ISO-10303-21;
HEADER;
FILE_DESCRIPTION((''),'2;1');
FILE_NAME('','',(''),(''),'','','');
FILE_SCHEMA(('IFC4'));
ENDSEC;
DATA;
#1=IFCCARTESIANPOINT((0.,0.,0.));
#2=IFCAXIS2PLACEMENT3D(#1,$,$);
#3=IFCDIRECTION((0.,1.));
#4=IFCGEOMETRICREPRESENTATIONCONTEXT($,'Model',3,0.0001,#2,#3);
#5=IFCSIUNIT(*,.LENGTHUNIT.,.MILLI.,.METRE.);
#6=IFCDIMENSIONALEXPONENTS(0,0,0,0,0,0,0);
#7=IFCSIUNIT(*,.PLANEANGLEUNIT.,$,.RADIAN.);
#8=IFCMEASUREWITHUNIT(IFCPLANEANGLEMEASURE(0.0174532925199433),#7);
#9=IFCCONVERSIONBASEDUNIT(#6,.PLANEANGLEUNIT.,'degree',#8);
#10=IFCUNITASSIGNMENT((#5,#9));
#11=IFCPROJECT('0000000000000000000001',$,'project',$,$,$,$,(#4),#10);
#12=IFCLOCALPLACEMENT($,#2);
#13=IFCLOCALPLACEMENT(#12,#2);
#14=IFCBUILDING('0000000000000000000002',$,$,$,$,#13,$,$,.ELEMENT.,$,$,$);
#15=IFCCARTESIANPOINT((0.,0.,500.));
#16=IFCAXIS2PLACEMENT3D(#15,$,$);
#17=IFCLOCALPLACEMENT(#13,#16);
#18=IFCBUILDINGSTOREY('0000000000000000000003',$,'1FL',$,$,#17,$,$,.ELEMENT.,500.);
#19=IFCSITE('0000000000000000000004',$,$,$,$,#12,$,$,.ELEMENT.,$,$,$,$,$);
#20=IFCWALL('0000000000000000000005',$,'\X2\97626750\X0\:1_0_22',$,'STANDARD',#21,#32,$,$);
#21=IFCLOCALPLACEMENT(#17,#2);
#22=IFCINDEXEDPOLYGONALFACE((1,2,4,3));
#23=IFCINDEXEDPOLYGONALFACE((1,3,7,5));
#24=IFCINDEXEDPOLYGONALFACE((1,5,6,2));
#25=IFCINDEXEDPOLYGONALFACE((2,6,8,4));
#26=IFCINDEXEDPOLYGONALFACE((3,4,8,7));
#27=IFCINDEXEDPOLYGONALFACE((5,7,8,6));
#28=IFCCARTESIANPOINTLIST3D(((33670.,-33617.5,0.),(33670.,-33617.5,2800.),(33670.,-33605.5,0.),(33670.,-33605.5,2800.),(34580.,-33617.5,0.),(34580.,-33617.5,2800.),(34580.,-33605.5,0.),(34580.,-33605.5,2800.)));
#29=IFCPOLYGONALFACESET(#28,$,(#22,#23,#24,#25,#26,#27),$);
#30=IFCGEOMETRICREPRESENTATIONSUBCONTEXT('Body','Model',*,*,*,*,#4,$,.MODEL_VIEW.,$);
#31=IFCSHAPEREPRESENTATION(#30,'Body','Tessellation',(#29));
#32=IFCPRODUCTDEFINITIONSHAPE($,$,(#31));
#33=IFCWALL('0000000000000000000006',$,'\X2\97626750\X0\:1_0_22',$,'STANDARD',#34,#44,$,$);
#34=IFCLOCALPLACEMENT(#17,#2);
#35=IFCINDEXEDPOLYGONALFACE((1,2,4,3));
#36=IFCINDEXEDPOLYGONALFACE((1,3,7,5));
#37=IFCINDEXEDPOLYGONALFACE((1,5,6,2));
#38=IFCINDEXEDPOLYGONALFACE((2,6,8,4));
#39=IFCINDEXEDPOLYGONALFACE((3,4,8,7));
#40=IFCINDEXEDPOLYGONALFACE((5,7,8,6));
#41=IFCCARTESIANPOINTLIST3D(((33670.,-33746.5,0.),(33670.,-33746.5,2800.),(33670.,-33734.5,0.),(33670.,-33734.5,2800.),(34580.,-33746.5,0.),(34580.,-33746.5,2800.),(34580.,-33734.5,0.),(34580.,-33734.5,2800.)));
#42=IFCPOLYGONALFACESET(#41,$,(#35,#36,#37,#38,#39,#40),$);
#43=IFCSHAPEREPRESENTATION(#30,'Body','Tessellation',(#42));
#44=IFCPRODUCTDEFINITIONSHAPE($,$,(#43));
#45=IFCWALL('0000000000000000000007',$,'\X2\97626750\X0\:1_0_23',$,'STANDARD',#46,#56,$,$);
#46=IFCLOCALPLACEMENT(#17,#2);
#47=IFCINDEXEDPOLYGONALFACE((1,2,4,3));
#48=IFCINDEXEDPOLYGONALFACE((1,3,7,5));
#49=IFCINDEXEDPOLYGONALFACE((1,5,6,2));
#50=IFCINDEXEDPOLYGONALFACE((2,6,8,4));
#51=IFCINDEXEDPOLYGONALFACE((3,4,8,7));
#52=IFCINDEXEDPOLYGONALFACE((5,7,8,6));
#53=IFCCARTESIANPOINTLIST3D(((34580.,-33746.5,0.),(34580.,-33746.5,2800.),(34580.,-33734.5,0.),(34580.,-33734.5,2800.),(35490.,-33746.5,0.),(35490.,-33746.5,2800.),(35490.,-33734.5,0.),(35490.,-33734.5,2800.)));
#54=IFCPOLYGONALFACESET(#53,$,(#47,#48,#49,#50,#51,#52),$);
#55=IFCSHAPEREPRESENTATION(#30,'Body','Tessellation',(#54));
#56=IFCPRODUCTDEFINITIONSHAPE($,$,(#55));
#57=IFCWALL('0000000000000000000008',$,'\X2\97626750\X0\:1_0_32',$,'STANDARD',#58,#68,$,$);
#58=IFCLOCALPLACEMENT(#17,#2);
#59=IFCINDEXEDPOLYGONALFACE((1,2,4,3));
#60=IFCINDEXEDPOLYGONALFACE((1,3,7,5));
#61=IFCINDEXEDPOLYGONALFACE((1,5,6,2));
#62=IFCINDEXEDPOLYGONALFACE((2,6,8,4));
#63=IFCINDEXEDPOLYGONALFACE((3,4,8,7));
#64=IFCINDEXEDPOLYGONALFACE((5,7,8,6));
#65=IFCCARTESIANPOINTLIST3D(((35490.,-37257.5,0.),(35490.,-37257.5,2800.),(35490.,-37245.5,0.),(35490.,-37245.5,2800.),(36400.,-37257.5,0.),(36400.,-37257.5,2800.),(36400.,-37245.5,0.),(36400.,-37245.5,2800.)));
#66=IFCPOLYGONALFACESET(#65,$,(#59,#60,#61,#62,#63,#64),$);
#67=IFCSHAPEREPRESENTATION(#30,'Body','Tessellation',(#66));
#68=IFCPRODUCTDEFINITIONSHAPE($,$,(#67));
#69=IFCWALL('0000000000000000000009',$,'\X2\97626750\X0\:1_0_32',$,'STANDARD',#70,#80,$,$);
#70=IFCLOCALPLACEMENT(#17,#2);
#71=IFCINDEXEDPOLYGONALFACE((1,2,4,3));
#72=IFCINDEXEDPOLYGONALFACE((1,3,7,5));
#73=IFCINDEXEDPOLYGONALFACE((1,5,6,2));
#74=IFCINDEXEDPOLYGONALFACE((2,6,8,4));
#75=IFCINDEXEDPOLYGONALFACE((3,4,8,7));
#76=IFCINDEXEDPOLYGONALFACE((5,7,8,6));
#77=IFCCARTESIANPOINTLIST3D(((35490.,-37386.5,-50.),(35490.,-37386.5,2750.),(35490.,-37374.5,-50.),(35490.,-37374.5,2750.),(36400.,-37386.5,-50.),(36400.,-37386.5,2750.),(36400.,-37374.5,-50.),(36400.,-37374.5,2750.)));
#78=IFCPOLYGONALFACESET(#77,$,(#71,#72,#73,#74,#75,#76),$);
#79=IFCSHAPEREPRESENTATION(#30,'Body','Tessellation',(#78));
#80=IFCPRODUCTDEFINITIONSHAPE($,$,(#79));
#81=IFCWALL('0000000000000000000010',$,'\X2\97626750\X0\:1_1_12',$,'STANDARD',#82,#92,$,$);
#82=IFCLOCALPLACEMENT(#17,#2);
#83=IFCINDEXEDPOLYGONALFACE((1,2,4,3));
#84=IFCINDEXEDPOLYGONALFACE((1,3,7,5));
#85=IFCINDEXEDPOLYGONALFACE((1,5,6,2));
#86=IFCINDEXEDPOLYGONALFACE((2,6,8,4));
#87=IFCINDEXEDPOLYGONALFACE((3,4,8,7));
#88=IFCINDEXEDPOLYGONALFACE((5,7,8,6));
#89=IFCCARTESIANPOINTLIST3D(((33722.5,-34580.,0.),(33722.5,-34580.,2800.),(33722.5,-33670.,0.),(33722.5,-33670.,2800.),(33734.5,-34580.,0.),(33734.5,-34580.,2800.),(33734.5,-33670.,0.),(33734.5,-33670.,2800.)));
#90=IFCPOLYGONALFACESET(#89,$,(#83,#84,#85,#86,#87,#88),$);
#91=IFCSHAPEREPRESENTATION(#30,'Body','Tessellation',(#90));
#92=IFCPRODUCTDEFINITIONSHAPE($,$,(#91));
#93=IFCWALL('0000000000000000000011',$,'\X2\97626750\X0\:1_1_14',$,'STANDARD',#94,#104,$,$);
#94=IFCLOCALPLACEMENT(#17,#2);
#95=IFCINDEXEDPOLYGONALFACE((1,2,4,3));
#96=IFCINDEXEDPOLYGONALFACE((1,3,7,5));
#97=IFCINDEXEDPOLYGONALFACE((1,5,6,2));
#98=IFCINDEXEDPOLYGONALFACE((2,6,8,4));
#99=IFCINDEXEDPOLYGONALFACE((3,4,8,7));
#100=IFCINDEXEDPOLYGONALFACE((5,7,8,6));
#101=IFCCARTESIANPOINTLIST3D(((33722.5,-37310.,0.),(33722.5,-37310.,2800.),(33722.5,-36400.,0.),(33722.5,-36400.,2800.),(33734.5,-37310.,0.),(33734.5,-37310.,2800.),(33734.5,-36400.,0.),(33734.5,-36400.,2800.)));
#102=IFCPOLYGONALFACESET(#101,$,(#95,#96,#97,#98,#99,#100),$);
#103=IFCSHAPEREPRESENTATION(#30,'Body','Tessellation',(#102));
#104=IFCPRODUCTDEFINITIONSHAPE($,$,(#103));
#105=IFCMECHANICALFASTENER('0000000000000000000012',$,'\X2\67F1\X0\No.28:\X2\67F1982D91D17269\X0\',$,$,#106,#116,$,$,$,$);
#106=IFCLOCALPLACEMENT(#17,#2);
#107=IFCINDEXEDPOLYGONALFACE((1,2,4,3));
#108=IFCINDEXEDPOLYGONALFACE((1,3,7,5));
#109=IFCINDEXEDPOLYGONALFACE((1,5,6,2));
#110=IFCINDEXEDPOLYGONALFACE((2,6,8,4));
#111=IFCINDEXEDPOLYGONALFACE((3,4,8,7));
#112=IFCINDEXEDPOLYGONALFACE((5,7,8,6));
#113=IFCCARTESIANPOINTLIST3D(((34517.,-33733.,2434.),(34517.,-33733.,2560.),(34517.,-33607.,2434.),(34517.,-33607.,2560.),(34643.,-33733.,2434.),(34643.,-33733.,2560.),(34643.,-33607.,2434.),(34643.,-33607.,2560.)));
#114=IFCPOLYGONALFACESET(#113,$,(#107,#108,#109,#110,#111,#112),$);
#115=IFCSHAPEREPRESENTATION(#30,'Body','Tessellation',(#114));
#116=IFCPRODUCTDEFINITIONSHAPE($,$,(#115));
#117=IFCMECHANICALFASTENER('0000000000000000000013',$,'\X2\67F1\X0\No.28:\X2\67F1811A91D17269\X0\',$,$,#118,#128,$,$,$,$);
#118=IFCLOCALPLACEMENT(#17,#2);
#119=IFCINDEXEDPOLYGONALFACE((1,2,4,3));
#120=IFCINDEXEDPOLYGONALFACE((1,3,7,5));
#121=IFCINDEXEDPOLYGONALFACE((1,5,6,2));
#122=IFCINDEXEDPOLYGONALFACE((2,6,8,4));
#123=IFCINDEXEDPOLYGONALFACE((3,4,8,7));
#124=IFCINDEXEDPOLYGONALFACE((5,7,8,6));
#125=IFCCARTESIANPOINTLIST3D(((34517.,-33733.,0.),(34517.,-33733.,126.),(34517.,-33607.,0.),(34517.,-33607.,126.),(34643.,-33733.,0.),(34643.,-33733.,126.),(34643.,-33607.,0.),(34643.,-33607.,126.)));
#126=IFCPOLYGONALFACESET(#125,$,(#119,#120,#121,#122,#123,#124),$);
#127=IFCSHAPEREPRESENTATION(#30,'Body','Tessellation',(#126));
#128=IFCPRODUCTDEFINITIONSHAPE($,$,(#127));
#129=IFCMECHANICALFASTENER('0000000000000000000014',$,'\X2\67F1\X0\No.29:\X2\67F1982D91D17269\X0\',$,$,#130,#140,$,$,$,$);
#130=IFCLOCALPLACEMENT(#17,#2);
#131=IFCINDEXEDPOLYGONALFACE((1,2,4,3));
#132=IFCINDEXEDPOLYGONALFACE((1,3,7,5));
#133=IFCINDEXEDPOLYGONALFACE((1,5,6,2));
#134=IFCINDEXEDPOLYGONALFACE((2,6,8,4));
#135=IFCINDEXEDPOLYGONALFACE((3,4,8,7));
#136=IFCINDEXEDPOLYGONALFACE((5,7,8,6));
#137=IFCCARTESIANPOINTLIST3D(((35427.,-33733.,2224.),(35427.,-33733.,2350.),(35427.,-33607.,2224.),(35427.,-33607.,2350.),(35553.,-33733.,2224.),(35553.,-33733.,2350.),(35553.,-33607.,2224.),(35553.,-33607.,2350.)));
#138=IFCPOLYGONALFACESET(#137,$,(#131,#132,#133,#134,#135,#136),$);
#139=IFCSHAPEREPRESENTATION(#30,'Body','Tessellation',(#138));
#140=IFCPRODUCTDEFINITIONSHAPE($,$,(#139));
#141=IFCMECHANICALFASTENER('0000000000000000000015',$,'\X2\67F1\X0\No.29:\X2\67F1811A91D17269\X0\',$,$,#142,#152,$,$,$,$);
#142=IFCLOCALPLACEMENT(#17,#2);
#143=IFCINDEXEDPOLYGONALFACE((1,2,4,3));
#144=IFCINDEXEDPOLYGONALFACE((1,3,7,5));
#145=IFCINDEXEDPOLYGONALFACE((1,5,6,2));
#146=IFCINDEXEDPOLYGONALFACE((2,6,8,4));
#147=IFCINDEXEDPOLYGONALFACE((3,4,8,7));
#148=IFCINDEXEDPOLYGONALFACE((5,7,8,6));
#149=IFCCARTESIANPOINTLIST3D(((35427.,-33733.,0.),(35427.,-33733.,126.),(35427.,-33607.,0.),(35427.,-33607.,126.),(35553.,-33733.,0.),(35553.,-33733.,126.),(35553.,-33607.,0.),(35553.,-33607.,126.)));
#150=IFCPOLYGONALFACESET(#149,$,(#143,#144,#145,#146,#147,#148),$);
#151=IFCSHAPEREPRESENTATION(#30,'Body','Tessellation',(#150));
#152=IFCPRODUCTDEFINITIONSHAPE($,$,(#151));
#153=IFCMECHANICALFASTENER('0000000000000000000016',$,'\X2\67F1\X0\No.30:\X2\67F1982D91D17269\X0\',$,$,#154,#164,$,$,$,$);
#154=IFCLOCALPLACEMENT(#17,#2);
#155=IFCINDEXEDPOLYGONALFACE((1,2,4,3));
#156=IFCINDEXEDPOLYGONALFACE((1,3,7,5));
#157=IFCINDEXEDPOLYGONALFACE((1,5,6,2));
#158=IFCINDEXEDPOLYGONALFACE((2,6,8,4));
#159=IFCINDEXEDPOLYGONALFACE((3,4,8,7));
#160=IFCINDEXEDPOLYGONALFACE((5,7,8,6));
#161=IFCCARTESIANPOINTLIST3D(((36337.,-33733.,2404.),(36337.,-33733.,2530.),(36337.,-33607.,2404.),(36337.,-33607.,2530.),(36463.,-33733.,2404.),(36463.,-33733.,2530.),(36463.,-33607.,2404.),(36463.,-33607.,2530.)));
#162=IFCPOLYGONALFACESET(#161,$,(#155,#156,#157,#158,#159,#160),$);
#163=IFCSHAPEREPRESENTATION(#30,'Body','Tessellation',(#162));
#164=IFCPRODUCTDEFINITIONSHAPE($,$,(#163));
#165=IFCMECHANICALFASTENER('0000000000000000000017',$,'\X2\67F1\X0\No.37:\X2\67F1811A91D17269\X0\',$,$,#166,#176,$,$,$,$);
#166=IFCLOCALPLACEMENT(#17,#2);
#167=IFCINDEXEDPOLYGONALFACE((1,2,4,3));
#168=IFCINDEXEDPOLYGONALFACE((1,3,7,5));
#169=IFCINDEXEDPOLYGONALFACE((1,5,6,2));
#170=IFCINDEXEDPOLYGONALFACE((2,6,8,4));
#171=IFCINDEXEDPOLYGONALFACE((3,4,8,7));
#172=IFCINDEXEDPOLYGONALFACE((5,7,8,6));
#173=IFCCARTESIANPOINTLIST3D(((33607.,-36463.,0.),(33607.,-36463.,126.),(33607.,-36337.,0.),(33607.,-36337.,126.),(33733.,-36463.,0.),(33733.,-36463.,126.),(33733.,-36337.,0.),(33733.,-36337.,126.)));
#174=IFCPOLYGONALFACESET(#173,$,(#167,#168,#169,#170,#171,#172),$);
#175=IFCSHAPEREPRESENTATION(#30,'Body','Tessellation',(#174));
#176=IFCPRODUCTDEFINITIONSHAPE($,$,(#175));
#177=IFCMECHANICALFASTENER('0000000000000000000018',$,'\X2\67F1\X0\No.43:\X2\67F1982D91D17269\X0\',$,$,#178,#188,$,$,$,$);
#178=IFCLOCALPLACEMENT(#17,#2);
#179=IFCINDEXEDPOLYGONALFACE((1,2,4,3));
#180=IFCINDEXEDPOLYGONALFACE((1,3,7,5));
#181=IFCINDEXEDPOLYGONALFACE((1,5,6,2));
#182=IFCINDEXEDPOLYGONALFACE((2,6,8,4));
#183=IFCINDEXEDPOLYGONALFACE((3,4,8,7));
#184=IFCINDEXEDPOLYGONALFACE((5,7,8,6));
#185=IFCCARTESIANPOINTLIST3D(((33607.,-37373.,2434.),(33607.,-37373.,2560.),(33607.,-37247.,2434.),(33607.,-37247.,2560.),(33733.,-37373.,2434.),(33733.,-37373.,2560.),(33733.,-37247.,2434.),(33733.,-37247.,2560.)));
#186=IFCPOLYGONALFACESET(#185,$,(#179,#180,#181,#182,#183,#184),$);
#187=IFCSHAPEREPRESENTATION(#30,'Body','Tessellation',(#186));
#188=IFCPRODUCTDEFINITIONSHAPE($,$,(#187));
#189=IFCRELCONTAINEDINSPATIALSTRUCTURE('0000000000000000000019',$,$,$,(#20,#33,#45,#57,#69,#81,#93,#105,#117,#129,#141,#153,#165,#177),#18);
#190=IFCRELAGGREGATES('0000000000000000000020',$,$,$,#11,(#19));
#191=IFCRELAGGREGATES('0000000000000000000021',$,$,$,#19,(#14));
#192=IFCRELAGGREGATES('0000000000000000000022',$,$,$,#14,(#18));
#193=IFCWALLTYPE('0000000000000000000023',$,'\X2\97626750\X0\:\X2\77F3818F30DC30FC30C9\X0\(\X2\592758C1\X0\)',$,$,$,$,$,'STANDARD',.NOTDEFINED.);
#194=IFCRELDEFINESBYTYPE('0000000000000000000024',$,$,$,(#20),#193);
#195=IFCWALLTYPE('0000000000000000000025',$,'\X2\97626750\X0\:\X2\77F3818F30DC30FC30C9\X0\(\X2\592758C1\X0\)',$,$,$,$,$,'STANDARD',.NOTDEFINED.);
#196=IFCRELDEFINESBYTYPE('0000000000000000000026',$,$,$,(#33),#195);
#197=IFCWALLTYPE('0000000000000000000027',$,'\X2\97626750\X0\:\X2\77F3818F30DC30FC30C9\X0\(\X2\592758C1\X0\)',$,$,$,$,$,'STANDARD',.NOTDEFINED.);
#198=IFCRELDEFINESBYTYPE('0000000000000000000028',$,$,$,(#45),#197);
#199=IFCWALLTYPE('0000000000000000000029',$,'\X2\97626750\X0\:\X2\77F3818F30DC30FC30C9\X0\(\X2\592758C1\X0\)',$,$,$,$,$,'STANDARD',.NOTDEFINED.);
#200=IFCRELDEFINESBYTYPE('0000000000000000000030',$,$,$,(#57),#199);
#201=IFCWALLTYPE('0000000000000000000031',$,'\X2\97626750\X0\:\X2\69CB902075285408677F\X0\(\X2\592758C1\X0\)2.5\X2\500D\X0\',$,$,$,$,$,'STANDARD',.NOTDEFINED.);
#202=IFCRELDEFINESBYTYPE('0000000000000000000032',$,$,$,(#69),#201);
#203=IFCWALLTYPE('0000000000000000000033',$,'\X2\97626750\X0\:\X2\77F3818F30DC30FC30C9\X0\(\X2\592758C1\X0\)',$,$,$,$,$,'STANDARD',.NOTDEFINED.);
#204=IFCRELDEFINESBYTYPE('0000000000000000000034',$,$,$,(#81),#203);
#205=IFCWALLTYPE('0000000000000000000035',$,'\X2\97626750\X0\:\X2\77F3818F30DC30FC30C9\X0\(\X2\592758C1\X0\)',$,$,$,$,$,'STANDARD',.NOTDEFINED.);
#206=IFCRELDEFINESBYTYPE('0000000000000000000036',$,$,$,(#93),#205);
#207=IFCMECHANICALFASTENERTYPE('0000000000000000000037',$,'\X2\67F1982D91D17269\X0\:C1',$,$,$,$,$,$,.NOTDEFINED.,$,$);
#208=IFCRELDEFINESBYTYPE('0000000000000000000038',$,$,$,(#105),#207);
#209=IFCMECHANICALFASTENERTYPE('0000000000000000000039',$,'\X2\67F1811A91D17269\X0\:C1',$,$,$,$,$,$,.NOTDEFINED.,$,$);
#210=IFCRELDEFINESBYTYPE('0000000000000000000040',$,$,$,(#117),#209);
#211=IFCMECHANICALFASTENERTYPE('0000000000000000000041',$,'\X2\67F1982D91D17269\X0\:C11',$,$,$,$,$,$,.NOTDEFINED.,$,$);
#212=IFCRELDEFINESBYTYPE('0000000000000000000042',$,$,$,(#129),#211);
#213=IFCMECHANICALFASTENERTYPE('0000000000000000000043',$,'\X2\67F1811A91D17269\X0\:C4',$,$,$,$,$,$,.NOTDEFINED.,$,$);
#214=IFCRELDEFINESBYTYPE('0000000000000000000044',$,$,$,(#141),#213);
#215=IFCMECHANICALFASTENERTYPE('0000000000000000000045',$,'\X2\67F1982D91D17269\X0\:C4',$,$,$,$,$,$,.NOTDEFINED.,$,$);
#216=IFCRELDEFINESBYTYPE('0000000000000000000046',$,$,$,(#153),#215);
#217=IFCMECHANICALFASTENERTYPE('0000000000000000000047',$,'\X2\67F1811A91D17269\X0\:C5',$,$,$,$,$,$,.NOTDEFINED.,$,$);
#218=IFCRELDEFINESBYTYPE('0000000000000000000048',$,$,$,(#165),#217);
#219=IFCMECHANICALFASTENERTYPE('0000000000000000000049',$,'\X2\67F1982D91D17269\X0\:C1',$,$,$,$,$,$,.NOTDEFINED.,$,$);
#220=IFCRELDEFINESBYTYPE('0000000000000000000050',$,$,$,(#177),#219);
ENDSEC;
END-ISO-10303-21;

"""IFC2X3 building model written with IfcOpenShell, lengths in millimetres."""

from ifc_helpers import new_model, entity, si_unit, converted_unit, direction, frame, origin, origin_with_axes, origin_2d, place, context, subcontext, project, spatial, polyline, rectangle, outline, extrude, type_object, element, save


model = new_model("IFC2X3")

# Units and contexts
model_context = context("Model", 3, precision=0.0001, world=origin(), true_north=direction((0.0, 1.0)))
body_context = subcontext(model_context, "Body", "Model", "MODEL_VIEW")
ifc_project = project(units=[si_unit("LENGTHUNIT", "METRE", prefix="MILLI"), converted_unit("PLANEANGLEUNIT", "degree", entity("IfcPlaneAngleMeasure", 0.0174532925199433), si_unit("PLANEANGLEUNIT", "RADIAN"), dimensions=[0, 0, 0, 0, 0, 0, 0])], contexts=[model_context])

# Site, building, storey
site_placement = place(None, origin())
site = spatial("IfcSite", under=ifc_project, at=site_placement, CompositionType="ELEMENT")
building_placement = place(site_placement, origin())
building = spatial("IfcBuilding", under=site, at=building_placement, CompositionType="ELEMENT")
storey_placement = place(building_placement, frame((0.0, 0.0, 500.0)))
storey = spatial("IfcBuildingStorey", under=building, at=storey_placement, Name="1FL", CompositionType="ELEMENT", Elevation=500.0)

# Walls
wall_type_1 = type_object("IfcWallType", Name="面材:石膏ボード(大壁)", ElementType="STANDARD", PredefinedType="NOTDEFINED")
wall_1_placement = place(storey_placement, frame((34125.0, -33605.5, 0.0), z_axis=(0.0, -1.0, 0.0), x_axis=(1.0, 0.0, 0.0)))
element("IfcWall", 1, at=wall_1_placement, inside=storey, type_object=wall_type_1, Name="面材:1_0_22", ObjectType="STANDARD", context=body_context, shape_type="SweptSolid", body=[
    extrude(outline(polyline([(455.0, 0.0, 0.0), (-455.0, 0.0, 0.0), (-455.0, 2800.0, 0.0), (455.0, 2800.0, 0.0), (455.0, 0.0, 0.0)])), origin_with_axes(), (0.0, 0.0, 1.0), 12.0),
])
wall_type_2 = type_object("IfcWallType", Name="面材:石膏ボード(大壁)", ElementType="STANDARD", PredefinedType="NOTDEFINED")
wall_2_placement = place(storey_placement, frame((34125.0, -33734.5, 0.0), z_axis=(0.0, -1.0, 0.0), x_axis=(1.0, 0.0, 0.0)))
element("IfcWall", 2, at=wall_2_placement, inside=storey, type_object=wall_type_2, Name="面材:1_0_22", ObjectType="STANDARD", context=body_context, shape_type="SweptSolid", body=[
    extrude(outline(polyline([(455.0, 0.0, 0.0), (-455.0, 0.0, 0.0), (-455.0, 2800.0, 0.0), (455.0, 2800.0, 0.0), (455.0, 0.0, 0.0)])), origin_with_axes(), (0.0, 0.0, 1.0), 12.0),
])
wall_type_3 = type_object("IfcWallType", Name="面材:石膏ボード(大壁)", ElementType="STANDARD", PredefinedType="NOTDEFINED")
wall_3_placement = place(storey_placement, frame((35035.0, -33734.5, 0.0), z_axis=(0.0, -1.0, 0.0), x_axis=(1.0, 0.0, 0.0)))
element("IfcWall", 3, at=wall_3_placement, inside=storey, type_object=wall_type_3, Name="面材:1_0_23", ObjectType="STANDARD", context=body_context, shape_type="SweptSolid", body=[
    extrude(outline(polyline([(455.0, 0.0, 0.0), (-455.0, 0.0, 0.0), (-455.0, 2800.0, 0.0), (455.0, 2800.0, 0.0), (455.0, 0.0, 0.0)])), origin_with_axes(), (0.0, 0.0, 1.0), 12.0),
])
wall_type_4 = type_object("IfcWallType", Name="面材:石膏ボード(大壁)", ElementType="STANDARD", PredefinedType="NOTDEFINED")
wall_4_placement = place(storey_placement, frame((35945.0, -37245.5, 0.0), z_axis=(0.0, -1.0, 0.0), x_axis=(1.0, 0.0, 0.0)))
element("IfcWall", 4, at=wall_4_placement, inside=storey, type_object=wall_type_4, Name="面材:1_0_32", ObjectType="STANDARD", context=body_context, shape_type="SweptSolid", body=[
    extrude(outline(polyline([(455.0, 0.0, 0.0), (-455.0, 0.0, 0.0), (-455.0, 2800.0, 0.0), (455.0, 2800.0, 0.0), (455.0, 0.0, 0.0)])), origin_with_axes(), (0.0, 0.0, 1.0), 12.0),
])
wall_type_5 = type_object("IfcWallType", Name="面材:構造用合板(大壁)2.5倍", ElementType="STANDARD", PredefinedType="NOTDEFINED")
wall_5_placement = place(storey_placement, frame((35945.0, -37374.5, -50.0), z_axis=(0.0, -1.0, 0.0), x_axis=(1.0, 0.0, 0.0)))
element("IfcWall", 5, at=wall_5_placement, inside=storey, type_object=wall_type_5, Name="面材:1_0_32", ObjectType="STANDARD", context=body_context, shape_type="SweptSolid", body=[
    extrude(outline(polyline([(455.0, 0.0, 0.0), (-455.0, 0.0, 0.0), (-455.0, 2800.0, 0.0), (455.0, 2800.0, 0.0), (455.0, 0.0, 0.0)])), origin_with_axes(), (0.0, 0.0, 1.0), 12.0),
])
wall_type_6 = type_object("IfcWallType", Name="面材:石膏ボード(大壁)", ElementType="STANDARD", PredefinedType="NOTDEFINED")
wall_6_placement = place(storey_placement, frame((33734.5, -34125.0, 0.0), z_axis=(-1.0, 0.0, 0.0), x_axis=(0.0, -1.0, 0.0)))
element("IfcWall", 6, at=wall_6_placement, inside=storey, type_object=wall_type_6, Name="面材:1_1_12", ObjectType="STANDARD", context=body_context, shape_type="SweptSolid", body=[
    extrude(outline(polyline([(455.0, 0.0, 0.0), (-455.0, 0.0, 0.0), (-455.0, 2800.0, 0.0), (455.0, 2800.0, 0.0), (455.0, 0.0, 0.0)])), origin_with_axes(), (0.0, 0.0, 1.0), 12.0),
])
wall_type_7 = type_object("IfcWallType", Name="面材:石膏ボード(大壁)", ElementType="STANDARD", PredefinedType="NOTDEFINED")
wall_7_placement = place(storey_placement, frame((33734.5, -36855.0, 0.0), z_axis=(-1.0, 0.0, 0.0), x_axis=(0.0, -1.0, 0.0)))
element("IfcWall", 7, at=wall_7_placement, inside=storey, type_object=wall_type_7, Name="面材:1_1_14", ObjectType="STANDARD", context=body_context, shape_type="SweptSolid", body=[
    extrude(outline(polyline([(455.0, 0.0, 0.0), (-455.0, 0.0, 0.0), (-455.0, 2800.0, 0.0), (455.0, 2800.0, 0.0), (455.0, 0.0, 0.0)])), origin_with_axes(), (0.0, 0.0, 1.0), 12.0),
])

# Mechanical fasteners
mechanical_fastener_type_1 = type_object("IfcMechanicalFastenerType", Name="柱頭金物:C1")
mechanical_fastener_1_placement = place(storey_placement, frame((34580.0, -33670.0, 2434.0)))
element("IfcMechanicalFastener", 8, at=mechanical_fastener_1_placement, inside=storey, type_object=mechanical_fastener_type_1, Name="柱No.28:柱頭金物", context=body_context, shape_type="SweptSolid", body=[
    extrude(rectangle(XDim=126.0, YDim=126.0, at=origin_2d()), origin_with_axes(), (0.0, 0.0, 1.0), 126.0),
])
mechanical_fastener_type_2 = type_object("IfcMechanicalFastenerType", Name="柱脚金物:C1")
mechanical_fastener_2_placement = place(storey_placement, frame((34580.0, -33670.0, 0.0)))
element("IfcMechanicalFastener", 9, at=mechanical_fastener_2_placement, inside=storey, type_object=mechanical_fastener_type_2, Name="柱No.28:柱脚金物", context=body_context, shape_type="SweptSolid", body=[
    extrude(rectangle(XDim=126.0, YDim=126.0, at=origin_2d()), origin_with_axes(), (0.0, 0.0, 1.0), 126.0),
])
mechanical_fastener_type_3 = type_object("IfcMechanicalFastenerType", Name="柱頭金物:C11")
mechanical_fastener_3_placement = place(storey_placement, frame((35490.0, -33670.0, 2224.0)))
element("IfcMechanicalFastener", 10, at=mechanical_fastener_3_placement, inside=storey, type_object=mechanical_fastener_type_3, Name="柱No.29:柱頭金物", context=body_context, shape_type="SweptSolid", body=[
    extrude(rectangle(XDim=126.0, YDim=126.0, at=origin_2d()), origin_with_axes(), (0.0, 0.0, 1.0), 126.0),
])
mechanical_fastener_type_4 = type_object("IfcMechanicalFastenerType", Name="柱脚金物:C4")
mechanical_fastener_4_placement = place(storey_placement, frame((35490.0, -33670.0, 0.0)))
element("IfcMechanicalFastener", 11, at=mechanical_fastener_4_placement, inside=storey, type_object=mechanical_fastener_type_4, Name="柱No.29:柱脚金物", context=body_context, shape_type="SweptSolid", body=[
    extrude(rectangle(XDim=126.0, YDim=126.0, at=origin_2d()), origin_with_axes(), (0.0, 0.0, 1.0), 126.0),
])
mechanical_fastener_type_5 = type_object("IfcMechanicalFastenerType", Name="柱頭金物:C4")
mechanical_fastener_5_placement = place(storey_placement, frame((36400.0, -33670.0, 2404.0)))
element("IfcMechanicalFastener", 12, at=mechanical_fastener_5_placement, inside=storey, type_object=mechanical_fastener_type_5, Name="柱No.30:柱頭金物", context=body_context, shape_type="SweptSolid", body=[
    extrude(rectangle(XDim=126.0, YDim=126.0, at=origin_2d()), origin_with_axes(), (0.0, 0.0, 1.0), 126.0),
])
mechanical_fastener_type_6 = type_object("IfcMechanicalFastenerType", Name="柱脚金物:C5")
mechanical_fastener_6_placement = place(storey_placement, frame((33670.0, -36400.0, 0.0)))
element("IfcMechanicalFastener", 13, at=mechanical_fastener_6_placement, inside=storey, type_object=mechanical_fastener_type_6, Name="柱No.37:柱脚金物", context=body_context, shape_type="SweptSolid", body=[
    extrude(rectangle(XDim=126.0, YDim=126.0, at=origin_2d()), origin_with_axes(), (0.0, 0.0, 1.0), 126.0),
])
mechanical_fastener_type_7 = type_object("IfcMechanicalFastenerType", Name="柱頭金物:C1")
mechanical_fastener_7_placement = place(storey_placement, frame((33670.0, -37310.0, 2434.0)))
element("IfcMechanicalFastener", 14, at=mechanical_fastener_7_placement, inside=storey, type_object=mechanical_fastener_type_7, Name="柱No.43:柱頭金物", context=body_context, shape_type="SweptSolid", body=[
    extrude(rectangle(XDim=126.0, YDim=126.0, at=origin_2d()), origin_with_axes(), (0.0, 0.0, 1.0), 126.0),
])

save(model, "model.ifc")
